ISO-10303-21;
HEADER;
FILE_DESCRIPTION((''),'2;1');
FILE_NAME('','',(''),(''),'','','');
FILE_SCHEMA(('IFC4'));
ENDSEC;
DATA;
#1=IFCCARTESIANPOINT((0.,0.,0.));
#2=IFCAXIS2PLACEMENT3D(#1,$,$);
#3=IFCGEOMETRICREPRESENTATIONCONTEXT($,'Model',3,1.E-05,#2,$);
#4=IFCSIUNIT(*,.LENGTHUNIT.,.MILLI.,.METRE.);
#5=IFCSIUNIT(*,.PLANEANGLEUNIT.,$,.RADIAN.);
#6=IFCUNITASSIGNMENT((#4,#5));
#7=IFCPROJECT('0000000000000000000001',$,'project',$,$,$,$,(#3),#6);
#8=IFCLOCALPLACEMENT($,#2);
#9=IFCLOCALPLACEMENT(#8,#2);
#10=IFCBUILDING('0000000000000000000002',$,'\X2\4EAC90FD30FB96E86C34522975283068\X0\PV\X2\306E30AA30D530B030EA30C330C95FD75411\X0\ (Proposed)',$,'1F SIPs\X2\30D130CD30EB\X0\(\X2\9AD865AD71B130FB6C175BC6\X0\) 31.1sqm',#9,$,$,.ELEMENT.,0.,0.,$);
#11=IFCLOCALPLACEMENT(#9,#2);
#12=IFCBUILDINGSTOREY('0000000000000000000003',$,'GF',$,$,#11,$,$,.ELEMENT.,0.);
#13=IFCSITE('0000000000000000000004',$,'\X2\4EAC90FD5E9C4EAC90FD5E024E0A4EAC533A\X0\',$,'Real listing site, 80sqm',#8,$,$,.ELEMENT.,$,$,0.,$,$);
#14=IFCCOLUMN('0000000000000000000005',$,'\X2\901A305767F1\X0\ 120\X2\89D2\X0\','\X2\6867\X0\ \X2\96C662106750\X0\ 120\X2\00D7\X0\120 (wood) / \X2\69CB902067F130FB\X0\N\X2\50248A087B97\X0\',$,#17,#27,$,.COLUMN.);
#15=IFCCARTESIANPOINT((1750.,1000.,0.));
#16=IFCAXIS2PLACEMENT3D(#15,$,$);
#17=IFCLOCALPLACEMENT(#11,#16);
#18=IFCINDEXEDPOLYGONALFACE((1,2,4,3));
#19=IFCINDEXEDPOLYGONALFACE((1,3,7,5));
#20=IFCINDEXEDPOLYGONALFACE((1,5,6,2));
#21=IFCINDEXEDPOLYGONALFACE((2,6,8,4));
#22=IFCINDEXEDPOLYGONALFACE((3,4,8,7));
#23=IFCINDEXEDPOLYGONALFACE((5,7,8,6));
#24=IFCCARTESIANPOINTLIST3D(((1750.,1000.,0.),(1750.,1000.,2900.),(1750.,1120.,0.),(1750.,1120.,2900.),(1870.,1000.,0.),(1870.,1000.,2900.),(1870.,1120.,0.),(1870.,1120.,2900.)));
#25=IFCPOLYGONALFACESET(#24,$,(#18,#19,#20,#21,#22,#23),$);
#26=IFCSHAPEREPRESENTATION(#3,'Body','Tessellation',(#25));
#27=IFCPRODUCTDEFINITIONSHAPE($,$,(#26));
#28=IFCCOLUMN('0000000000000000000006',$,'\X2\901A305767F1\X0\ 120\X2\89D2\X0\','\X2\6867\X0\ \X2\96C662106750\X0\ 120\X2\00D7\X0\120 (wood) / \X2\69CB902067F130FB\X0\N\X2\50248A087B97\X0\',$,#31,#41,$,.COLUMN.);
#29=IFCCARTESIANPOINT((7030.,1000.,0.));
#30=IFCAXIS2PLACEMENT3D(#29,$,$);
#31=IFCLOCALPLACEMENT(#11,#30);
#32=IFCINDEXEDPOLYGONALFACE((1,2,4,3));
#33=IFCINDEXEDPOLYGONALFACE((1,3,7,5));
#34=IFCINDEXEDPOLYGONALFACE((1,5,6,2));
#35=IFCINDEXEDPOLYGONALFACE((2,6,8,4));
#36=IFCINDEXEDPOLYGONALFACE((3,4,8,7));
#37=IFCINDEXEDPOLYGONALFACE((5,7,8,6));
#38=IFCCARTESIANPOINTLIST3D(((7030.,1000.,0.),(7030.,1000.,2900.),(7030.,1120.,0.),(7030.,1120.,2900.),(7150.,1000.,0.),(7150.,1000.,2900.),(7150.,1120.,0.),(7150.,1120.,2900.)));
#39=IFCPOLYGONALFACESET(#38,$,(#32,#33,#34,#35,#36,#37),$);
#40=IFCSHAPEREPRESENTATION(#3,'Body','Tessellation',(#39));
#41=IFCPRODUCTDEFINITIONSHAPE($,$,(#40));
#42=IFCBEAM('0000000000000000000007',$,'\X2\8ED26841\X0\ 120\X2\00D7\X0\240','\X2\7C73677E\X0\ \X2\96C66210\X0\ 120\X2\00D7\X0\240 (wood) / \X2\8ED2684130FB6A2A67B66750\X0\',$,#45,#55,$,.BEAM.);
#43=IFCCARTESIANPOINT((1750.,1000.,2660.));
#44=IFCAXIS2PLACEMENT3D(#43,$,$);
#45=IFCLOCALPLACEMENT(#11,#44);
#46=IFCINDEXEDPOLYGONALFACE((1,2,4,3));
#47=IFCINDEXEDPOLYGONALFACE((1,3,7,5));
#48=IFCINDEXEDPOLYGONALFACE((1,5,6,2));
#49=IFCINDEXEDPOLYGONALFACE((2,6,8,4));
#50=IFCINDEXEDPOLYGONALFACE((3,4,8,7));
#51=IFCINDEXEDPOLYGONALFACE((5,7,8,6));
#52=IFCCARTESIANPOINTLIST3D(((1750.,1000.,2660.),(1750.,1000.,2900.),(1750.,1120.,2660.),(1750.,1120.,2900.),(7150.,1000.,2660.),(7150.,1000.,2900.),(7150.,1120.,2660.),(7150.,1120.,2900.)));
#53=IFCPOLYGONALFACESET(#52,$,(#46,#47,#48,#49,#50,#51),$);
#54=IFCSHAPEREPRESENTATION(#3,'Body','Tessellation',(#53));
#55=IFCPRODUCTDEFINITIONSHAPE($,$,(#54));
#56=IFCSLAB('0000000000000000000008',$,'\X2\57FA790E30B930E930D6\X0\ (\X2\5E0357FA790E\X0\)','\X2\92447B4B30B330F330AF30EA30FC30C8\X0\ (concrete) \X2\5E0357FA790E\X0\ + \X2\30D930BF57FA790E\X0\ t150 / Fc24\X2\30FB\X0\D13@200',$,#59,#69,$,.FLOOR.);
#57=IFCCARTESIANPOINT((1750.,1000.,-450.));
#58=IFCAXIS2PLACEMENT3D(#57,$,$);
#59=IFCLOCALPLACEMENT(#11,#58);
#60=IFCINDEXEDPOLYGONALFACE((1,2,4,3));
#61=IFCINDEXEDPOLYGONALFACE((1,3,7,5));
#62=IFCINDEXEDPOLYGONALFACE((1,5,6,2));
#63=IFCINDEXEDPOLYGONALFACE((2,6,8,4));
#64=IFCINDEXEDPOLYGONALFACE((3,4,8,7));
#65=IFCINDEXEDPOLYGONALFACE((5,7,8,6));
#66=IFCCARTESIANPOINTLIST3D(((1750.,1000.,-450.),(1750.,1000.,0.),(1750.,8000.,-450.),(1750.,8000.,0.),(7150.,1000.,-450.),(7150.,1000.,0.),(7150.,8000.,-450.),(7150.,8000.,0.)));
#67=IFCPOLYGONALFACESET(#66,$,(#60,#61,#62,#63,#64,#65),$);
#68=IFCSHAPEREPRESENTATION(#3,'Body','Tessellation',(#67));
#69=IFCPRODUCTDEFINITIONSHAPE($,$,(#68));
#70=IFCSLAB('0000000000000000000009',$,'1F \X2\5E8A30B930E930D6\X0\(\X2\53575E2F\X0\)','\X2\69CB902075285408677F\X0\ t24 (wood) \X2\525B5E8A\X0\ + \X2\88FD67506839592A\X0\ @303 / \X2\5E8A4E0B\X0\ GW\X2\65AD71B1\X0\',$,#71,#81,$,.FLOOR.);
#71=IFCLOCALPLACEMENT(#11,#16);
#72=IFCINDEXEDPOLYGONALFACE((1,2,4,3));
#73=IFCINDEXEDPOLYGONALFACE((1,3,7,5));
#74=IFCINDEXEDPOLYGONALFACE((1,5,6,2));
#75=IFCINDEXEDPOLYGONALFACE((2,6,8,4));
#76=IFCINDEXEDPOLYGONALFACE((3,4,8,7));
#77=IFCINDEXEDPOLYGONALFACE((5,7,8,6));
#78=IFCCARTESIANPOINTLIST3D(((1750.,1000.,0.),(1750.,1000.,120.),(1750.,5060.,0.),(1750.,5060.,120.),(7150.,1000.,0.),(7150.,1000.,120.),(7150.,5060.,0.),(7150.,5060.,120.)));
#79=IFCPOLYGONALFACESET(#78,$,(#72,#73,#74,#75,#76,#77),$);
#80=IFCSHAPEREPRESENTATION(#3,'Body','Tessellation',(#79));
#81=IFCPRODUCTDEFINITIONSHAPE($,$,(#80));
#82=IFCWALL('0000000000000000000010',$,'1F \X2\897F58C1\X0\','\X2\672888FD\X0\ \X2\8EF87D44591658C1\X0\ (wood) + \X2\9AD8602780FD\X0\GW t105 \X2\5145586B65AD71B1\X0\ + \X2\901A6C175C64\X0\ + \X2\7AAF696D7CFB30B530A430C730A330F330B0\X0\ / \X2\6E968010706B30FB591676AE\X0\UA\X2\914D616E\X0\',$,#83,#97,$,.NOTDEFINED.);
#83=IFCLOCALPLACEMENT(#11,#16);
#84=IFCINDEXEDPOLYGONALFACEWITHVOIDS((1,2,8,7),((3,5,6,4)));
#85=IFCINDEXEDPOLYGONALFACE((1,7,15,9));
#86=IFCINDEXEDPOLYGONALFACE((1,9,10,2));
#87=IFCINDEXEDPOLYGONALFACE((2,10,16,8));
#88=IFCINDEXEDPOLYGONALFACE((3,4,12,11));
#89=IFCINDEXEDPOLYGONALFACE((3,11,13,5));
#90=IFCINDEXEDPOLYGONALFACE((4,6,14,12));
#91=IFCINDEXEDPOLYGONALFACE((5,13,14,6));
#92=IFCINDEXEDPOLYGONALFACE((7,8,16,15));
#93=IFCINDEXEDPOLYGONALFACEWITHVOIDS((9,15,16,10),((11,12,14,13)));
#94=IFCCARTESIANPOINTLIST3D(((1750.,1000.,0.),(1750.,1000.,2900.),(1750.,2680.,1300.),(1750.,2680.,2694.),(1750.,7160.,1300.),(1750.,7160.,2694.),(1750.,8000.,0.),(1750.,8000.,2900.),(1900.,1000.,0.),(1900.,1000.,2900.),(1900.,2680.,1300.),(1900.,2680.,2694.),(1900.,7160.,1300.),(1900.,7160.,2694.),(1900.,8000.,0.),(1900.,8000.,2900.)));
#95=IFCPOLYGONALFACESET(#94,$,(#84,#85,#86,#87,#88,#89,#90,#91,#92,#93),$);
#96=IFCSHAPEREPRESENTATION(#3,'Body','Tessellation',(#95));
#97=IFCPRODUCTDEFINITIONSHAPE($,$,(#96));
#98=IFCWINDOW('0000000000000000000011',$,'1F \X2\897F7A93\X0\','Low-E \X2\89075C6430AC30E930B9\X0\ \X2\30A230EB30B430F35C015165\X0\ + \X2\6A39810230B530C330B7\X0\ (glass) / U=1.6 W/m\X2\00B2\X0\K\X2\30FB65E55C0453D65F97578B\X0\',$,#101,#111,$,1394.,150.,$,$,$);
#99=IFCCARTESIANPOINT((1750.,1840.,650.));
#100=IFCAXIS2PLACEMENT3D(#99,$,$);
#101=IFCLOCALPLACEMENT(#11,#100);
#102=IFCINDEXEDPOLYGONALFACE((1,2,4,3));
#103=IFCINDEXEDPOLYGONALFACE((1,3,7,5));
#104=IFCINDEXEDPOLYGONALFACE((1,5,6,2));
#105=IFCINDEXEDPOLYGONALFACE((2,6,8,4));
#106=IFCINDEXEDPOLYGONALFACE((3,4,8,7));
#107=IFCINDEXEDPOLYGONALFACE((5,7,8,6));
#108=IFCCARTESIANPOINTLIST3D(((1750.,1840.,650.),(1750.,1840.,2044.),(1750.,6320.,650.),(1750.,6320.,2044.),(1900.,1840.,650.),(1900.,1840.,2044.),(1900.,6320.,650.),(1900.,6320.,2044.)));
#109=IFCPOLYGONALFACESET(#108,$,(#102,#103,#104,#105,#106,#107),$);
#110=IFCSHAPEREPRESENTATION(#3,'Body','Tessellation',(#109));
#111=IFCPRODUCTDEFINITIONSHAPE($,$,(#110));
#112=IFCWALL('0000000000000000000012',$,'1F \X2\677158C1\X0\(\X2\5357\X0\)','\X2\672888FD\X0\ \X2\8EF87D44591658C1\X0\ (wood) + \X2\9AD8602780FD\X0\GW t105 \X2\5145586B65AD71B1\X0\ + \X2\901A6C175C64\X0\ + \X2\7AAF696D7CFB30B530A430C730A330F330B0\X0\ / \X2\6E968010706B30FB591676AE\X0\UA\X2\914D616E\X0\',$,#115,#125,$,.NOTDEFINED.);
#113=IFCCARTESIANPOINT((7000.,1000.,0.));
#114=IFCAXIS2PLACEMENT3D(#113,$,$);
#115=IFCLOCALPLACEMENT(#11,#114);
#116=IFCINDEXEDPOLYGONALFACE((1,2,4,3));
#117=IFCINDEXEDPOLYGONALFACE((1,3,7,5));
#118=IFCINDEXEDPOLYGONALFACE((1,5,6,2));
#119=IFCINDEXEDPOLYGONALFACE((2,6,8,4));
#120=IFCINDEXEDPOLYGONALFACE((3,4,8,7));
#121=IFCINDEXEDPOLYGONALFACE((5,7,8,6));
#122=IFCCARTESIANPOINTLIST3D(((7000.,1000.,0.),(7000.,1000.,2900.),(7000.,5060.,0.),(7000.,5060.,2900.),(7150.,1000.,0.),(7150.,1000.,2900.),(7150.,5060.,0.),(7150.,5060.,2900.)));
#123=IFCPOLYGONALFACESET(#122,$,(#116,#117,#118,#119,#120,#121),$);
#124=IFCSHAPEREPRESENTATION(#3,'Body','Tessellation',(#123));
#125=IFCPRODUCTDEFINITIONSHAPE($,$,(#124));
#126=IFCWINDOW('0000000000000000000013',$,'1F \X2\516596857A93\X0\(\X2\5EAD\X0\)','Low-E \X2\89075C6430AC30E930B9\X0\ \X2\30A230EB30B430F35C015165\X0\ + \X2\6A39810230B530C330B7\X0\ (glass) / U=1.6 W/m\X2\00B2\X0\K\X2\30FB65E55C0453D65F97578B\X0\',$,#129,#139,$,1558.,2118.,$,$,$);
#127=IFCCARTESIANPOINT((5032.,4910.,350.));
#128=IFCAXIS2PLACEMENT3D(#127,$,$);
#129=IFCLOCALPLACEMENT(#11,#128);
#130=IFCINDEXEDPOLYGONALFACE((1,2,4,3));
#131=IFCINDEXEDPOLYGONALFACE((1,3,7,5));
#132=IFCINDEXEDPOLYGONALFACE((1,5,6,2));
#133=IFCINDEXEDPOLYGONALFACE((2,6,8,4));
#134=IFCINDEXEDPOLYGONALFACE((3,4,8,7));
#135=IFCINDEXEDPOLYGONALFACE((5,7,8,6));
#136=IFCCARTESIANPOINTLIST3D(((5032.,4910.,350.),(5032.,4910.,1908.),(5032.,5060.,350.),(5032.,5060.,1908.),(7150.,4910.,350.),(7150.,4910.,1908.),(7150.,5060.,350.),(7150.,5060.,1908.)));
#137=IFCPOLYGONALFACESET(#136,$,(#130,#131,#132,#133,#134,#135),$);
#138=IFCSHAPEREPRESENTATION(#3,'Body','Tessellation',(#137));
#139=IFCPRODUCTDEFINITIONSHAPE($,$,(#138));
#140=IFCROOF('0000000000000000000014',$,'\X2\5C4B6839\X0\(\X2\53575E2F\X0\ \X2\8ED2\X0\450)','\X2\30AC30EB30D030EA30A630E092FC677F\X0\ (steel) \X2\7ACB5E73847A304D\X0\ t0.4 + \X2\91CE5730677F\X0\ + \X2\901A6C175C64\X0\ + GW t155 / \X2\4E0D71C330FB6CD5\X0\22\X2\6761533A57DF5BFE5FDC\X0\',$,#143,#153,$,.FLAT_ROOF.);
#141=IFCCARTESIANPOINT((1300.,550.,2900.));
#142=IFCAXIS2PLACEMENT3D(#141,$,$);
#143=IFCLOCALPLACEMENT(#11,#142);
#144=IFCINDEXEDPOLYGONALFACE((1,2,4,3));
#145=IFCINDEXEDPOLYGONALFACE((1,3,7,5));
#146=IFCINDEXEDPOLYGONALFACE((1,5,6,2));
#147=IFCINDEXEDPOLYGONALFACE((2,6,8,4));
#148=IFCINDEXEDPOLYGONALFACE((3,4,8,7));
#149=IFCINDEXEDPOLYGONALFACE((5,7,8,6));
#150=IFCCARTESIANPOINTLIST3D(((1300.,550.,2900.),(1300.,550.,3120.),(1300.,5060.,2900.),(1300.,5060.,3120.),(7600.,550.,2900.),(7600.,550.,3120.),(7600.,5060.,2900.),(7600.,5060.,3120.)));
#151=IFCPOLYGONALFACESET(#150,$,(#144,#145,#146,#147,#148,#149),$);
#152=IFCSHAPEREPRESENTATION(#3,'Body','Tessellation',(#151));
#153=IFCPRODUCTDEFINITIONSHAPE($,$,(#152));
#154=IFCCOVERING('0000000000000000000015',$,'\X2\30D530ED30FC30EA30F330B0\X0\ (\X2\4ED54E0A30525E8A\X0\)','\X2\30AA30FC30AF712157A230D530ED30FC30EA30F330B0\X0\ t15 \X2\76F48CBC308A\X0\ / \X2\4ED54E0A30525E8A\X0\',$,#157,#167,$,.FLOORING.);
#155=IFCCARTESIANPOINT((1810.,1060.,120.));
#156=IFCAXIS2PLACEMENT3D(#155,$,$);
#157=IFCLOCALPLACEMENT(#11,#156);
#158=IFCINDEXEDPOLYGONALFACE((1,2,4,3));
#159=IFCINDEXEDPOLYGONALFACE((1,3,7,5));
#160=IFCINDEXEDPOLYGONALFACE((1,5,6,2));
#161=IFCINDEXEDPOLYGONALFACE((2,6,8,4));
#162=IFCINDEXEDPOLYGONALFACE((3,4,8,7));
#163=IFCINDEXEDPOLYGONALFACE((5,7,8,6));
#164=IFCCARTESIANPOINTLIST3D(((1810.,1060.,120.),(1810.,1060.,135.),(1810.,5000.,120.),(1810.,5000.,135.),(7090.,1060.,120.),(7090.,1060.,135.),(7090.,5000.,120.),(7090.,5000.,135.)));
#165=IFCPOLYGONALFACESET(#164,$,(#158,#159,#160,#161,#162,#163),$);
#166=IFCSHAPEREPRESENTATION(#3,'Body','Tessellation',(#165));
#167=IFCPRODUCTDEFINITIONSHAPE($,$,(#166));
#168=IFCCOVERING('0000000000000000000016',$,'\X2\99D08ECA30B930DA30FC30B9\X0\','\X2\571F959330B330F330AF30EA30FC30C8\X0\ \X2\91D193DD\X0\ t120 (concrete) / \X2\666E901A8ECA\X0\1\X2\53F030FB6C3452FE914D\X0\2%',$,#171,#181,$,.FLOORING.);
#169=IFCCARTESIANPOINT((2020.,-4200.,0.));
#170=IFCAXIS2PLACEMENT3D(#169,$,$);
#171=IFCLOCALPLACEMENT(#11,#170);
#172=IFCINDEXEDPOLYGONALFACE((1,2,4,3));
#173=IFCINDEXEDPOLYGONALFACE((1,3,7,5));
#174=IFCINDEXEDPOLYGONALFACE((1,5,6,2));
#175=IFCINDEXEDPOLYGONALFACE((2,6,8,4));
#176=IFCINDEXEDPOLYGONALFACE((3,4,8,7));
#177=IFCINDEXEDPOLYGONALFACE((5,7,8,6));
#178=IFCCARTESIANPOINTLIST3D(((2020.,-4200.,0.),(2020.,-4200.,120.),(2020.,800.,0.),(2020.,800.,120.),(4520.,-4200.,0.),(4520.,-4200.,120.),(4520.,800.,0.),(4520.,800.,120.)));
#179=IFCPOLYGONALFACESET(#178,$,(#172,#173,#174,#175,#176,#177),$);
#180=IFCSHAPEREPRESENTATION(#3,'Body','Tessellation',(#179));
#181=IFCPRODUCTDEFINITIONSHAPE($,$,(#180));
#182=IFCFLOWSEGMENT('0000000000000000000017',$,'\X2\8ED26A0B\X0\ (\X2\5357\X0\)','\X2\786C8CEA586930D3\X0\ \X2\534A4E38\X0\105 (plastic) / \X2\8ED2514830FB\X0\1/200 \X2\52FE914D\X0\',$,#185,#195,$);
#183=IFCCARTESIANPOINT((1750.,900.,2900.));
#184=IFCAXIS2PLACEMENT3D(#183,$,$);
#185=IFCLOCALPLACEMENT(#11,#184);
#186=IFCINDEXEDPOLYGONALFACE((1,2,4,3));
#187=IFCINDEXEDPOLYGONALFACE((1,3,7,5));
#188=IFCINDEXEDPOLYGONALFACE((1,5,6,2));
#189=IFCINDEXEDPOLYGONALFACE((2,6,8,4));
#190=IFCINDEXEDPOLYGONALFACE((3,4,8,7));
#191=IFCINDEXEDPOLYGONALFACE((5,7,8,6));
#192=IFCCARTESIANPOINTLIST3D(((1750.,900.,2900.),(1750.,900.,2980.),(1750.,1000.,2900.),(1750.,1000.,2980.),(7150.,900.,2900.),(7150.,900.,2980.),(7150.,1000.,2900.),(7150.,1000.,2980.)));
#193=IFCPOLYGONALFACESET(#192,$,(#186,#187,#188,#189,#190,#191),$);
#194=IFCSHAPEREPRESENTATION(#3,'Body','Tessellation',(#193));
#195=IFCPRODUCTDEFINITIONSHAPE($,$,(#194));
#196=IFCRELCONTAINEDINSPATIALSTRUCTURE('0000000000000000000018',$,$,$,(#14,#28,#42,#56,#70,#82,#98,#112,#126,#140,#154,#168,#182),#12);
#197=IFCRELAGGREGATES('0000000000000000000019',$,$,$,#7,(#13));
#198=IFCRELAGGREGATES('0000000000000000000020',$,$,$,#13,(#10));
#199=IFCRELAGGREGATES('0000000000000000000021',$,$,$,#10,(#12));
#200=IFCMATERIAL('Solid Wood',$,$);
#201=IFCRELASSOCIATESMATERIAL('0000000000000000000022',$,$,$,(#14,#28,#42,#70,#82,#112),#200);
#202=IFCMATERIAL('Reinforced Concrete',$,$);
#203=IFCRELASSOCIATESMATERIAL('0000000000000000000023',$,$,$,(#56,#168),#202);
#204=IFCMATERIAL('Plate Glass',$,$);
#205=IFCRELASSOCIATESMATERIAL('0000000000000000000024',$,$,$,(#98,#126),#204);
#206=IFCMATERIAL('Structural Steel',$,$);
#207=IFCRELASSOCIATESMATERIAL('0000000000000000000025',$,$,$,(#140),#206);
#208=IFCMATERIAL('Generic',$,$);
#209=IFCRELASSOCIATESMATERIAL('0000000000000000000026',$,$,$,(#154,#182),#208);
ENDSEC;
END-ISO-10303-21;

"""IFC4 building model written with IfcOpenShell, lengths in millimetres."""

from ifc_helpers import new_model, si_unit, frame, frame_2d, origin, place, context, project, spatial, rectangle, extrude, material, element, fill, save


model = new_model("IFC4")

# Units and contexts
model_context = context("Model", 3, precision=1e-05, world=origin())
ifc_project = project(units=[si_unit("LENGTHUNIT", "METRE", prefix="MILLI"), si_unit("PLANEANGLEUNIT", "RADIAN")], contexts=[model_context])

# Site, building, storey
site_placement = place(None, origin())
site = spatial("IfcSite", under=ifc_project, at=site_placement, Name="京都府京都市上京区", ObjectType="Real listing site, 80sqm", CompositionType="ELEMENT", RefElevation=0.0)
building_placement = place(site_placement, origin())
building = spatial("IfcBuilding", under=site, at=building_placement, Name="京都・雨水利用とPVのオフグリッド志向 (Proposed)", ObjectType="1F SIPsパネル(高断熱・気密) 31.1sqm", CompositionType="ELEMENT", ElevationOfRefHeight=0.0, ElevationOfTerrain=0.0)
storey_placement = place(building_placement, origin())
storey = spatial("IfcBuildingStorey", under=building, at=storey_placement, Name="GF", CompositionType="ELEMENT", Elevation=0.0)

# Columns
ifc_material_1 = material(Name="Solid Wood")
column_1_placement = place(storey_placement, frame((1750.0, 1000.0, 0.0)))
element("IfcColumn", 1, at=column_1_placement, inside=storey, material=ifc_material_1, Name="通し柱 120角", Description="桧 集成材 120×120 (wood) / 構造柱・N値計算", PredefinedType="COLUMN", context=model_context, shape_type="SweptSolid", body=[
    extrude(rectangle(XDim=120.0, YDim=120.0, at=frame_2d((60.0, 60.0))), frame((1750.0, 1000.0, 0.0)), (0.0, 0.0, 1.0), 2900.0),
])
column_2_placement = place(storey_placement, frame((7030.0, 1000.0, 0.0)))
element("IfcColumn", 2, at=column_2_placement, inside=storey, material=ifc_material_1, Name="通し柱 120角", Description="桧 集成材 120×120 (wood) / 構造柱・N値計算", PredefinedType="COLUMN", context=model_context, shape_type="SweptSolid", body=[
    extrude(rectangle(XDim=120.0, YDim=120.0, at=frame_2d((60.0, 60.0))), frame((7030.0, 1000.0, 0.0)), (0.0, 0.0, 1.0), 2900.0),
])

# Beam
beam_1_placement = place(storey_placement, frame((1750.0, 1000.0, 2660.0)))
element("IfcBeam", 3, at=beam_1_placement, inside=storey, material=ifc_material_1, Name="軒桁 120×240", Description="米松 集成 120×240 (wood) / 軒桁・横架材", PredefinedType="BEAM", context=model_context, shape_type="SweptSolid", body=[
    extrude(rectangle(XDim=5400.0, YDim=120.0, at=frame_2d((2700.0, 60.0))), frame((1750.0, 1000.0, 2660.0)), (0.0, 0.0, 1.0), 240.0),
])

# Slabs
ifc_material_2 = material(Name="Reinforced Concrete")
slab_1_placement = place(storey_placement, frame((1750.0, 1000.0, -450.0)))
element("IfcSlab", 4, at=slab_1_placement, inside=storey, material=ifc_material_2, Name="基礎スラブ (布基礎)", Description="鉄筋コンクリート (concrete) 布基礎 + ベタ基礎 t150 / Fc24・D13@200", PredefinedType="FLOOR", context=model_context, shape_type="SweptSolid", body=[
    extrude(rectangle(XDim=5400.0, YDim=7000.0, at=frame_2d((2700.0, 3500.0))), frame((1750.0, 1000.0, -450.0)), (0.0, 0.0, 1.0), 450.0),
])
slab_2_placement = place(storey_placement, frame((1750.0, 1000.0, 0.0)))
element("IfcSlab", 5, at=slab_2_placement, inside=storey, material=ifc_material_1, Name="1F 床スラブ(南帯)", Description="構造用合板 t24 (wood) 剛床 + 製材根太 @303 / 床下 GW断熱", PredefinedType="FLOOR", context=model_context, shape_type="SweptSolid", body=[
    extrude(rectangle(XDim=5400.0, YDim=4060.0, at=frame_2d((2700.0, 2030.0))), frame((1750.0, 1000.0, 0.0)), (0.0, 0.0, 1.0), 120.0),
])

# Shared definitions
ifc_material_3 = material(Name="Plate Glass")

# Walls, openings, windows
wall_1_placement = place(storey_placement, frame((1750.0, 1000.0, 0.0)))
wall_1 = element("IfcWall", 6, at=wall_1_placement, inside=storey, material=ifc_material_1, Name="1F 西壁", Description="木製 軸組外壁 (wood) + 高性能GW t105 充填断熱 + 通気層 + 窯業系サイディング / 準耐火・外皮UA配慮", PredefinedType="NOTDEFINED", context=model_context, shape_type="SweptSolid", body=[
    extrude(rectangle(XDim=150.0, YDim=7000.0, at=frame_2d((75.0, 3500.0))), frame((1750.0, 1000.0, 0.0)), (0.0, 0.0, 1.0), 2900.0),
])
opening_1_placement = place(storey_placement, frame((1750.0, 1840.0, 650.0)))
opening_1 = element("IfcOpeningElement", 7, at=opening_1_placement, cuts=wall_1, PredefinedType="NOTDEFINED", context=model_context, shape_type="SweptSolid", body=[
    extrude(rectangle(XDim=150.0, YDim=4480.0, at=frame_2d((75.0, 2240.0))), frame((1750.0, 1840.0, 650.0)), (0.0, 0.0, 1.0), 1394.0),
])
window_1_placement = place(storey_placement, frame((1750.0, 1840.0, 650.0)))
window_1 = element("IfcWindow", 8, at=window_1_placement, inside=storey, material=ifc_material_3, Name="1F 西窓", Description="Low-E 複層ガラス アルゴン封入 + 樹脂サッシ (glass) / U=1.6 W/m²K・日射取得型", OverallHeight=1394.0, OverallWidth=150.0, context=model_context, shape_type="SweptSolid", body=[
    extrude(rectangle(XDim=150.0, YDim=4480.0, at=frame_2d((75.0, 2240.0))), frame((1750.0, 1840.0, 650.0)), (0.0, 0.0, 1.0), 1394.0),
])
fill(opening_1, window_1)
wall_2_placement = place(storey_placement, frame((7000.0, 1000.0, 0.0)))
wall_2 = element("IfcWall", 9, at=wall_2_placement, inside=storey, material=ifc_material_1, Name="1F 東壁(南)", Description="木製 軸組外壁 (wood) + 高性能GW t105 充填断熱 + 通気層 + 窯業系サイディング / 準耐火・外皮UA配慮", PredefinedType="NOTDEFINED", context=model_context, shape_type="SweptSolid", body=[
    extrude(rectangle(XDim=150.0, YDim=4060.0, at=frame_2d((75.0, 2030.0))), frame((7000.0, 1000.0, 0.0)), (0.0, 0.0, 1.0), 2900.0),
])
opening_2_placement = place(storey_placement, frame((5032.0, 4910.0, 350.0)))
opening_2 = element("IfcOpeningElement", 10, at=opening_2_placement, cuts=wall_2, PredefinedType="NOTDEFINED", context=model_context, shape_type="SweptSolid", body=[
    extrude(rectangle(XDim=2118.0, YDim=150.0, at=frame_2d((1059.0, 75.0))), frame((5032.0, 4910.0, 350.0)), (0.0, 0.0, 1.0), 1558.0),
])
window_2_placement = place(storey_placement, frame((5032.0, 4910.0, 350.0)))
window_2 = element("IfcWindow", 11, at=window_2_placement, inside=storey, material=ifc_material_3, Name="1F 入隅窓(庭)", Description="Low-E 複層ガラス アルゴン封入 + 樹脂サッシ (glass) / U=1.6 W/m²K・日射取得型", OverallHeight=1558.0, OverallWidth=2118.0, context=model_context, shape_type="SweptSolid", body=[
    extrude(rectangle(XDim=2118.0, YDim=150.0, at=frame_2d((1059.0, 75.0))), frame((5032.0, 4910.0, 350.0)), (0.0, 0.0, 1.0), 1558.0),
])
fill(opening_2, window_2)

# Roof
ifc_material_4 = material(Name="Structural Steel")
roof_placement = place(storey_placement, frame((1300.0, 550.0, 2900.0)))
element("IfcRoof", 12, at=roof_placement, inside=storey, material=ifc_material_4, Name="屋根(南帯 軒450)", Description="ガルバリウム鋼板 (steel) 立平葺き t0.4 + 野地板 + 通気層 + GW t155 / 不燃・法22条区域対応", PredefinedType="FLAT_ROOF", context=model_context, shape_type="SweptSolid", body=[
    extrude(rectangle(XDim=6300.0, YDim=4510.0, at=frame_2d((3150.0, 2255.0))), frame((1300.0, 550.0, 2900.0)), (0.0, 0.0, 1.0), 220.0),
])

# Coverings
ifc_material_5 = material(Name="Generic")
covering_1_placement = place(storey_placement, frame((1810.0, 1060.0, 120.0)))
element("IfcCovering", 13, at=covering_1_placement, inside=storey, material=ifc_material_5, Name="フローリング (仕上げ床)", Description="オーク無垢フローリング t15 直貼り / 仕上げ床", PredefinedType="FLOORING", context=model_context, shape_type="SweptSolid", body=[
    extrude(rectangle(XDim=5280.0, YDim=3940.0, at=frame_2d((2640.0, 1970.0))), frame((1810.0, 1060.0, 120.0)), (0.0, 0.0, 1.0), 15.0),
])
covering_2_placement = place(storey_placement, frame((2020.0, -4200.0, 0.0)))
element("IfcCovering", 14, at=covering_2_placement, inside=storey, material=ifc_material_2, Name="駐車スペース", Description="土間コンクリート 金鏝 t120 (concrete) / 普通車1台・水勾配2%", PredefinedType="FLOORING", context=model_context, shape_type="SweptSolid", body=[
    extrude(rectangle(XDim=2500.0, YDim=5000.0, at=frame_2d((1250.0, 2500.0))), frame((2020.0, -4200.0, 0.0)), (0.0, 0.0, 1.0), 120.0),
])

# Flow segment
flow_segment_1_placement = place(storey_placement, frame((1750.0, 900.0, 2900.0)))
element("IfcFlowSegment", 15, at=flow_segment_1_placement, inside=storey, material=ifc_material_5, Name="軒樋 (南)", Description="硬質塩ビ 半丸105 (plastic) / 軒先・1/200 勾配", context=model_context, shape_type="SweptSolid", body=[
    extrude(rectangle(XDim=5400.0, YDim=100.0, at=frame_2d((2700.0, 50.0))), frame((1750.0, 900.0, 2900.0)), (0.0, 0.0, 1.0), 80.0),
])

save(model, "model.ifc")
